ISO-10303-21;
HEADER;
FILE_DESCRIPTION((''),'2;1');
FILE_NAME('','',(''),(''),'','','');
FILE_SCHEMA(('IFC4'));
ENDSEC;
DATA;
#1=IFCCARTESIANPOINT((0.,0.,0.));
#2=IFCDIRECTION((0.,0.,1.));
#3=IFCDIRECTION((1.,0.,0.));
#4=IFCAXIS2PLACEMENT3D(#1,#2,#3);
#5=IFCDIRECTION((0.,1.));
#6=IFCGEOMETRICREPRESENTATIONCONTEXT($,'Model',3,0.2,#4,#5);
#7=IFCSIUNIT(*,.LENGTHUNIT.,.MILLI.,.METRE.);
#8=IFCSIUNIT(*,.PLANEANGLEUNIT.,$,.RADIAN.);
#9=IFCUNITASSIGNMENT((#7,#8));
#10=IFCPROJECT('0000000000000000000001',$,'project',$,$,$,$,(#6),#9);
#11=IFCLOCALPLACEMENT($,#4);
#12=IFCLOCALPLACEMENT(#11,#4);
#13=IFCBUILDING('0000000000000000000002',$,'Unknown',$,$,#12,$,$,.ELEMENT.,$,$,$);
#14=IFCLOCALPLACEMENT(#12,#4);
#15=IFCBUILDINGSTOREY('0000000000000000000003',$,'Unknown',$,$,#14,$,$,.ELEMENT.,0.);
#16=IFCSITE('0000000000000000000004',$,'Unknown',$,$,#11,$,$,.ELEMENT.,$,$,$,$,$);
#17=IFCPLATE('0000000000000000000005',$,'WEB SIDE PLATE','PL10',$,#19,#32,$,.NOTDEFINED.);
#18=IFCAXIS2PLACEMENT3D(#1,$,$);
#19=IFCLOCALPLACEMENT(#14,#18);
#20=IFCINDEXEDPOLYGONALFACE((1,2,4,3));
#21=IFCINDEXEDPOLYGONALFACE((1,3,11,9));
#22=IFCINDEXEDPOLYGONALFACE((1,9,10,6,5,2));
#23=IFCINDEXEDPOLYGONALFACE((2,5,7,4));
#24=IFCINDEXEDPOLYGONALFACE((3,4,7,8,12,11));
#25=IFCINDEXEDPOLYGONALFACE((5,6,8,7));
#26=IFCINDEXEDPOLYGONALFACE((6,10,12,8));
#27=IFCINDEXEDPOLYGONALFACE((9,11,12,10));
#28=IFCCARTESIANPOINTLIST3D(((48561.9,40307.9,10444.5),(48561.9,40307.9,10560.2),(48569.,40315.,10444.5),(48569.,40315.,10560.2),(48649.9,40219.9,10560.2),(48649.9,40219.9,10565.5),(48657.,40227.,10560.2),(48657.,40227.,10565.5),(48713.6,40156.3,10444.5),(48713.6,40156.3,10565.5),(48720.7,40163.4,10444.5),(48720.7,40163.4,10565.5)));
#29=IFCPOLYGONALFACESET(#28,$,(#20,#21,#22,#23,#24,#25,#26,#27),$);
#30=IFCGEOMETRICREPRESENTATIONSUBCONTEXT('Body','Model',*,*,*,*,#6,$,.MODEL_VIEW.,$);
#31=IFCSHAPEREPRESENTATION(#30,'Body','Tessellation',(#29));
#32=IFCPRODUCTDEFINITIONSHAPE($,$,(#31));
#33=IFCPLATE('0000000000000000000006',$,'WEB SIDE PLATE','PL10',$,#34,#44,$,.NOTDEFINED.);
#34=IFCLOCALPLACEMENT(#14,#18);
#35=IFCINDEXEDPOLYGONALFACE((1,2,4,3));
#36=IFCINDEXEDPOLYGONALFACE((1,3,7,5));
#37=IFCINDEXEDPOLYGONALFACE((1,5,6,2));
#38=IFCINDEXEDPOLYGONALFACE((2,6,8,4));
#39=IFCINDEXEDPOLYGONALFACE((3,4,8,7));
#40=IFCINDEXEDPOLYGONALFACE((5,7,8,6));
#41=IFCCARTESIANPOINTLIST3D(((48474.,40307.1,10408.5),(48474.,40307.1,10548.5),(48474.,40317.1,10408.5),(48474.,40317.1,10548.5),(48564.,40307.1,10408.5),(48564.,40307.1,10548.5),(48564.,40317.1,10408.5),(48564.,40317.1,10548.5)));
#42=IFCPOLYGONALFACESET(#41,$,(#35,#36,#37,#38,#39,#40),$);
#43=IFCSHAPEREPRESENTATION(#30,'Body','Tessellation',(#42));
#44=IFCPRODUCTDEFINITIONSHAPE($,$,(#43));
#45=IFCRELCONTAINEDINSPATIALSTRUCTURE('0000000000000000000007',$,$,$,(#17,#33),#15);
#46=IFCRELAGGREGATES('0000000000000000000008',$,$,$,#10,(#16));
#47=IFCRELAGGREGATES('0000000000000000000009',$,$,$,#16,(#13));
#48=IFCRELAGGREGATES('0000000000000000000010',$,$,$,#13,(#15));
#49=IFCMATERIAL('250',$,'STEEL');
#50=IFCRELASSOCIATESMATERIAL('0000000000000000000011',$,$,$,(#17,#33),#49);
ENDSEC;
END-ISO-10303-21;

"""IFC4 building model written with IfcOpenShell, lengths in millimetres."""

from ifc_helpers import new_model, si_unit, direction, frame, origin_with_axes, place, context, subcontext, project, spatial, line, indexed_curve, outline, extrude, material, element, save


model = new_model("IFC4")

# Units and contexts
model_context = context("Model", 3, precision=0.2, world=origin_with_axes(), true_north=direction((0.0, 1.0)))
body_context = subcontext(model_context, "Body", "Model", "MODEL_VIEW")
ifc_project = project(units=[si_unit("LENGTHUNIT", "METRE", prefix="MILLI"), si_unit("PLANEANGLEUNIT", "RADIAN")], contexts=[model_context])

# Site, building, storey
site_placement = place(None, origin_with_axes())
site = spatial("IfcSite", under=ifc_project, at=site_placement, Name="Unknown", CompositionType="ELEMENT")
building_placement = place(site_placement, origin_with_axes())
building = spatial("IfcBuilding", under=site, at=building_placement, Name="Unknown", CompositionType="ELEMENT")
storey_placement = place(building_placement, origin_with_axes())
storey = spatial("IfcBuildingStorey", under=building, at=storey_placement, Name="Unknown", CompositionType="ELEMENT", Elevation=0.0)

# Plates
ifc_material_1 = material(Name="250", Category="STEEL")
plate_1_placement = place(storey_placement, frame((48653.5, 40223.5, 10560.2), z_axis=(-0.707107, -0.707107, 0.0), x_axis=(-0.707107, 0.707107, 0.0)))
element("IfcPlate", 1, at=plate_1_placement, inside=storey, material=ifc_material_1, Name="WEB SIDE PLATE", Description="PL10", PredefinedType="NOTDEFINED", context=body_context, shape_type="SolidModel", body=[
    extrude(outline(indexed_curve([(0.0, 0.0), (124.5, 0.0), (124.5, 115.7), (-90.0, 115.7), (-90.0, -5.3), (0.0, -5.3)], segments=[line(1, 2, 3, 4, 5, 6, 1)])), frame((0.0, 0.0, 5.0), z_axis=(0.0, 0.0, 1.0), x_axis=(1.0, 0.0, 0.0)), (0.0, 0.0, -1.0), 10.0),
])
plate_2_placement = place(storey_placement, frame((48474.0, 40312.1, 10408.5), z_axis=(0.0, -1.0, 0.0), x_axis=(1.0, 0.0, 0.0)))
element("IfcPlate", 2, at=plate_2_placement, inside=storey, material=ifc_material_1, Name="WEB SIDE PLATE", Description="PL10", PredefinedType="NOTDEFINED", context=body_context, shape_type="SolidModel", body=[
    extrude(outline(indexed_curve([(0.0, 0.0), (90.0, 0.0), (90.0, 140.0), (0.0, 140.0)], segments=[line(1, 2, 3, 4, 1)])), frame((0.0, 0.0, 5.0), z_axis=(0.0, 0.0, 1.0), x_axis=(1.0, 0.0, 0.0)), (0.0, 0.0, -1.0), 10.0),
])

save(model, "model.ifc")
